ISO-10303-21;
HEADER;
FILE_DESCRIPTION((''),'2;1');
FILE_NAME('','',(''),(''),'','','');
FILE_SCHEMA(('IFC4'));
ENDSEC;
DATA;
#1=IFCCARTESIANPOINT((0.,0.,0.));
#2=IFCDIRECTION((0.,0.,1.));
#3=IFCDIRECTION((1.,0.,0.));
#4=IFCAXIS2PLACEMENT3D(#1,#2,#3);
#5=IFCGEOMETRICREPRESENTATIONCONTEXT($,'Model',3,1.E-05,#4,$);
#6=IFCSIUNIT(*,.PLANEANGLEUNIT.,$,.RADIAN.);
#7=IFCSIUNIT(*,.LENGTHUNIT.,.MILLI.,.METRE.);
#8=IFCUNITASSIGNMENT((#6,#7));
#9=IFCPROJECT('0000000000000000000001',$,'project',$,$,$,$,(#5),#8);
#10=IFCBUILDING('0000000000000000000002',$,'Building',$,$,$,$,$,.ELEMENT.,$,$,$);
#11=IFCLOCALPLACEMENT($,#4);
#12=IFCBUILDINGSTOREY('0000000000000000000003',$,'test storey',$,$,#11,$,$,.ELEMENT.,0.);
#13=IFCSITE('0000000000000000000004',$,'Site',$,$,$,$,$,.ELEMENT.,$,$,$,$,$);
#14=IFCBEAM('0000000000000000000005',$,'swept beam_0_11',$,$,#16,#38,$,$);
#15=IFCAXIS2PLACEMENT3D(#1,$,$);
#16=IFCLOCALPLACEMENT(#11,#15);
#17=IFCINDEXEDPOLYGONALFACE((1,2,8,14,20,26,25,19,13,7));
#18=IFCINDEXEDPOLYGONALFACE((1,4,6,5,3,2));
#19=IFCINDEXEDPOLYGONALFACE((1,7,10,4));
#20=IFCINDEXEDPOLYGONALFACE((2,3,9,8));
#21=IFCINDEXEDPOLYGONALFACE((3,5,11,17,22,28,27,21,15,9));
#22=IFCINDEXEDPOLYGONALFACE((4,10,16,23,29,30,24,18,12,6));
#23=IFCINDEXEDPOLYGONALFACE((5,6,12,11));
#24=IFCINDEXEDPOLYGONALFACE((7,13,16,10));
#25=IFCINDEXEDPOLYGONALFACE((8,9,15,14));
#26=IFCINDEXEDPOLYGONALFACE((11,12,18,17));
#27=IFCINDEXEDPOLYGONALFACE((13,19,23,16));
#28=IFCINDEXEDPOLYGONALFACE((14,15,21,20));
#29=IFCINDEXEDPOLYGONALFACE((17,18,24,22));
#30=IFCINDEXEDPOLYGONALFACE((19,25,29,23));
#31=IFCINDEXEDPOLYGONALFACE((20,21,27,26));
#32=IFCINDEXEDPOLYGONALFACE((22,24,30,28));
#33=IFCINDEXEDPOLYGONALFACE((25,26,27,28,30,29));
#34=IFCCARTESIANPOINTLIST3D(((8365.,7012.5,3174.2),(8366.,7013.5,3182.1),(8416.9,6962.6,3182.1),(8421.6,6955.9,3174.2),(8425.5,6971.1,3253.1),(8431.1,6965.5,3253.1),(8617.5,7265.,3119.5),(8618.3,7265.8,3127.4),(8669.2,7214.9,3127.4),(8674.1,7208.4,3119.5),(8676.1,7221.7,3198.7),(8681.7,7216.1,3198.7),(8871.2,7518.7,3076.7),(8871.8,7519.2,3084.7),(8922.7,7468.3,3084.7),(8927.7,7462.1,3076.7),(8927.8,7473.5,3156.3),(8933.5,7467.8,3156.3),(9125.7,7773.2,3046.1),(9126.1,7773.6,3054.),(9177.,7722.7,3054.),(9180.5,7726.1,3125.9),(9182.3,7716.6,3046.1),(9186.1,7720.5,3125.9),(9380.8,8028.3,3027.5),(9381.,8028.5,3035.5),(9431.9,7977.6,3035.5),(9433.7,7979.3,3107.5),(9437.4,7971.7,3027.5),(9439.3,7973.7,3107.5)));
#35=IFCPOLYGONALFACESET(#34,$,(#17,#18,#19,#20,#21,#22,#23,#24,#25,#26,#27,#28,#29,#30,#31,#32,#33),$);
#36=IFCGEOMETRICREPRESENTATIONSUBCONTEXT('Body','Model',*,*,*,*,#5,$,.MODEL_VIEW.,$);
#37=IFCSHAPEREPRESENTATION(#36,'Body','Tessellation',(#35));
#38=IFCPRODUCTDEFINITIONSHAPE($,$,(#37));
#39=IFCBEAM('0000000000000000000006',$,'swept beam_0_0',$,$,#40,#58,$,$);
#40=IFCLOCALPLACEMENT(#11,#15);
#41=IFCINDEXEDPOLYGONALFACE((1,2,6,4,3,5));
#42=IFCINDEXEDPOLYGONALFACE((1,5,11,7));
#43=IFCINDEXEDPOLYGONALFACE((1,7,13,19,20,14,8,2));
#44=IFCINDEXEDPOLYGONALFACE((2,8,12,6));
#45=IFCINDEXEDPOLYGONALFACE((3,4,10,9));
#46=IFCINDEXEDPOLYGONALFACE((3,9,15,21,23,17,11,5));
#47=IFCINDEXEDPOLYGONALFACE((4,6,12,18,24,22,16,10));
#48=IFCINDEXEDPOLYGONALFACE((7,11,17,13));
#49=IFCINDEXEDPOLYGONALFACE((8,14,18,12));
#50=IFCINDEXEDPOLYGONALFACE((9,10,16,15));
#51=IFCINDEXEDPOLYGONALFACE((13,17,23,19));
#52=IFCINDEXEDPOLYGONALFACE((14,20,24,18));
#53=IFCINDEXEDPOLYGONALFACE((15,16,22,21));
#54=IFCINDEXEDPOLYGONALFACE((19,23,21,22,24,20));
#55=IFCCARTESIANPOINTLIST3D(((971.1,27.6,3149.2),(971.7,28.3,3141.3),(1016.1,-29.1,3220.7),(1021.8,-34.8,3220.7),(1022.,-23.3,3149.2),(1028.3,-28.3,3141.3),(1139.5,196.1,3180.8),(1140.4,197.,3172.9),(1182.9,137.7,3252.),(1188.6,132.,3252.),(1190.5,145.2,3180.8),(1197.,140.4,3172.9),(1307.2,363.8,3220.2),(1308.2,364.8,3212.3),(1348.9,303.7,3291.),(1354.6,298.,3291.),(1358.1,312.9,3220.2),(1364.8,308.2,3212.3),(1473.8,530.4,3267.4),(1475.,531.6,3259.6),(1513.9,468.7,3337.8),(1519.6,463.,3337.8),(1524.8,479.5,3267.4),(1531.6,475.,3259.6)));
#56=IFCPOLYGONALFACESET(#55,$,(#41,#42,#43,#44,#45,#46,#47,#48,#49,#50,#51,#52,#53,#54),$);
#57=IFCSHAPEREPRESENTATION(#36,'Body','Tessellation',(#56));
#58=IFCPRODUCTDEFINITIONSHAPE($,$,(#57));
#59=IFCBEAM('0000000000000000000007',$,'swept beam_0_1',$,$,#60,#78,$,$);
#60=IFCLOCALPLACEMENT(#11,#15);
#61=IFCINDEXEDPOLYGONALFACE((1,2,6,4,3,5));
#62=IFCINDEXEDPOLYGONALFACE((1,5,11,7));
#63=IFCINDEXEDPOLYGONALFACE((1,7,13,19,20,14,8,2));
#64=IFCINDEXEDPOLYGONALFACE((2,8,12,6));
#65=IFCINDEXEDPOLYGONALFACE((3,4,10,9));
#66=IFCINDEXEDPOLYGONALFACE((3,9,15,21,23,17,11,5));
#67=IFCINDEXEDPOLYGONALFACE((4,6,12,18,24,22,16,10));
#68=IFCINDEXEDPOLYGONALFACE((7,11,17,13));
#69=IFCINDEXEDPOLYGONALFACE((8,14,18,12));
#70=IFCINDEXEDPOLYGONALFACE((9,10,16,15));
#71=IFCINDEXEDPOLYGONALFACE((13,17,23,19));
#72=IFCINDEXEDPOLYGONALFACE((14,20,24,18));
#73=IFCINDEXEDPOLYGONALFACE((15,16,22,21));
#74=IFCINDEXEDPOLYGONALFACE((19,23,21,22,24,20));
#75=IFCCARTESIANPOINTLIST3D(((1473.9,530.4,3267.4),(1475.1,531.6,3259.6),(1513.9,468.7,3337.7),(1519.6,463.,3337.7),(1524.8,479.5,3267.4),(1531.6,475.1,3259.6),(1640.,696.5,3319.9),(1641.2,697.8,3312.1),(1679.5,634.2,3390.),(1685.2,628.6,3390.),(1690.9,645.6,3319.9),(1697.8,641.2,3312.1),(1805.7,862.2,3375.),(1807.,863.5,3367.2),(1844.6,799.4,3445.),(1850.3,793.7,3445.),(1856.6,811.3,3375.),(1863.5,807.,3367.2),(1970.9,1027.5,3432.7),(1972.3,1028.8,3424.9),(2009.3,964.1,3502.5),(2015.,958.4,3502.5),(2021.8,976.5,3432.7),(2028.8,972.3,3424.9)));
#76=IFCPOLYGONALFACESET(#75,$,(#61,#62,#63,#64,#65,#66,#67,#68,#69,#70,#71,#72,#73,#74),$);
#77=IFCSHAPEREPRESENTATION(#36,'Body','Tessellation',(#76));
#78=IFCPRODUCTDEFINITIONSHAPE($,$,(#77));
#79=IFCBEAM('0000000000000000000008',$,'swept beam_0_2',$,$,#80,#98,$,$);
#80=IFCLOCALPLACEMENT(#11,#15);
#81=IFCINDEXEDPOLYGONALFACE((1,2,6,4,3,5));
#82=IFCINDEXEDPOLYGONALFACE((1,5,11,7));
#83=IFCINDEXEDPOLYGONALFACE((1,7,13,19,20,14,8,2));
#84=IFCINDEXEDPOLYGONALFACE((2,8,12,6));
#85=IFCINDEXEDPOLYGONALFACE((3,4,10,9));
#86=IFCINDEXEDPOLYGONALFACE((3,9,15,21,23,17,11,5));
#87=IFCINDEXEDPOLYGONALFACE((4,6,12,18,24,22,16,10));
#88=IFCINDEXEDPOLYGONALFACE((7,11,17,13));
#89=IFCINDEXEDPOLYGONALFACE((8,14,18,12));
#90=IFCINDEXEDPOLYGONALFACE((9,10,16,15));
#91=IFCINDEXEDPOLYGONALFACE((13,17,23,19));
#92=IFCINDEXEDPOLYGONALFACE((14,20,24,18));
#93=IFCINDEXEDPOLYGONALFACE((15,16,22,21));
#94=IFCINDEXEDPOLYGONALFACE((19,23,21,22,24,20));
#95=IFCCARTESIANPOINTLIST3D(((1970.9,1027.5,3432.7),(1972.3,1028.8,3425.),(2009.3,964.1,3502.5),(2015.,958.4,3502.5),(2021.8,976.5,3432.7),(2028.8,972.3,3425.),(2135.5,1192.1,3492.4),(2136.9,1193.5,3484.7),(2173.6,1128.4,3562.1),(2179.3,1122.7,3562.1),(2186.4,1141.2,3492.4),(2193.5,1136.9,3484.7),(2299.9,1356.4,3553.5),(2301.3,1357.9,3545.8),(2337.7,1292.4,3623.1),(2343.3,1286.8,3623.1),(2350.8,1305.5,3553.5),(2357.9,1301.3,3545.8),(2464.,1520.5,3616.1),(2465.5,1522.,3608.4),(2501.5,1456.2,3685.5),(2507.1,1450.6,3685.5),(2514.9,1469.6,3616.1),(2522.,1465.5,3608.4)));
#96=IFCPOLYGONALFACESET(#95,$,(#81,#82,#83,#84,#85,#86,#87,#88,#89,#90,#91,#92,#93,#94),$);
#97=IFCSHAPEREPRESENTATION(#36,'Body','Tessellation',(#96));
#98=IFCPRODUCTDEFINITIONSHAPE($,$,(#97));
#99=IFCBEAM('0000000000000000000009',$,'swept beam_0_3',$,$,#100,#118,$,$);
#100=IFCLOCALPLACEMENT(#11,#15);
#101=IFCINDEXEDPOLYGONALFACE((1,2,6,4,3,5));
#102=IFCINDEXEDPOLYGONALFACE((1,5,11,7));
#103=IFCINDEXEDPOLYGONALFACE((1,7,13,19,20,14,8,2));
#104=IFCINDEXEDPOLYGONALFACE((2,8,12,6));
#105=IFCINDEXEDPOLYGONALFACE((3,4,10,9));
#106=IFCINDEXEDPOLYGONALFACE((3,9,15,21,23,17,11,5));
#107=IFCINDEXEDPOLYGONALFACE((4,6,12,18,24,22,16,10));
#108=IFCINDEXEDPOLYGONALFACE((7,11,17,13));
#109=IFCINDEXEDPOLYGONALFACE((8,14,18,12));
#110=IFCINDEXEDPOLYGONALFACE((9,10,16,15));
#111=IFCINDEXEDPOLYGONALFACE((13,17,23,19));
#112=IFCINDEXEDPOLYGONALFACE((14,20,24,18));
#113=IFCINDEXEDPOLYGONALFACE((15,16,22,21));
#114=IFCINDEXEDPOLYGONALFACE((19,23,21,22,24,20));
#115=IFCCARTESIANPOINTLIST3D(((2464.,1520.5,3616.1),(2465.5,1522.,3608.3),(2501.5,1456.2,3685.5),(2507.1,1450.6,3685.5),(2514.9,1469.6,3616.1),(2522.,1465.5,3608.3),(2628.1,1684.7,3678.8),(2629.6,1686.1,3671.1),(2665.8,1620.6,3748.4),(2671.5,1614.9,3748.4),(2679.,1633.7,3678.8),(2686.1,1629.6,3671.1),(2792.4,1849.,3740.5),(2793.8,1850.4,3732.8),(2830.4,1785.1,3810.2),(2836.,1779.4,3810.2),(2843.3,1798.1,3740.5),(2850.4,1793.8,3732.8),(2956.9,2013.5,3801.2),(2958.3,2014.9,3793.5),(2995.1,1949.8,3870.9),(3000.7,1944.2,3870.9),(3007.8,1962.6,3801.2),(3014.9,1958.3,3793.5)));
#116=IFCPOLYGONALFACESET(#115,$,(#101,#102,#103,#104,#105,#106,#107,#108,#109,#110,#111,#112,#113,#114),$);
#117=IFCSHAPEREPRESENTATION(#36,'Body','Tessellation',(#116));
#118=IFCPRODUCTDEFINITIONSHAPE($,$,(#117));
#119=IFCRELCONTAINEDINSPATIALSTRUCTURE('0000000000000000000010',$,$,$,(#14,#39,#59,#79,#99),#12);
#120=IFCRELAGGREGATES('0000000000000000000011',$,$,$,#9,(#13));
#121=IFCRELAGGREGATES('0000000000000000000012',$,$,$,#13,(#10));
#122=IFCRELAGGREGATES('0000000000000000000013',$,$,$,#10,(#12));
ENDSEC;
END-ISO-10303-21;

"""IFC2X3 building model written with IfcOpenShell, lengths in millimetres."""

from ifc_helpers import new_model, entity, si_unit, origin_with_axes, place, context, subcontext, project, spatial, element, save


model = new_model("IFC2X3")

# Units and contexts
model_context = context("Model", 3, precision=1e-05, world=origin_with_axes())
body_context = subcontext(model_context, "Body", "Model", "MODEL_VIEW")
ifc_project = project(units=[si_unit("PLANEANGLEUNIT", "RADIAN"), si_unit("LENGTHUNIT", "METRE", prefix="MILLI")], contexts=[model_context])

# Site, building, storey
site = spatial("IfcSite", under=ifc_project, Name="Site", CompositionType="ELEMENT")
building = spatial("IfcBuilding", under=site, Name="Building", CompositionType="ELEMENT")
storey_placement = place(None, origin_with_axes())
storey = spatial("IfcBuildingStorey", under=building, at=storey_placement, Name="test storey", CompositionType="ELEMENT", Elevation=0.0)

# Beams
beam_1_placement = place(storey_placement, origin_with_axes())
element("IfcBeam", 1, at=beam_1_placement, inside=storey, Name="swept beam_0_11", context=body_context, shape_type="SweptSolid", body=[
    entity("IfcRevolvedAreaSolid", entity("IfcArbitraryClosedProfileDef", "AREA", None, entity("IfcPolyline", [entity("IfcCartesianPoint", [-80.0, 40.0]), entity("IfcCartesianPoint", [-80.0, 32.0]), entity("IfcCartesianPoint", [-8.0, 32.0]), entity("IfcCartesianPoint", [-8.0, -40.0]), entity("IfcCartesianPoint", [0.0, -40.0]), entity("IfcCartesianPoint", [0.0, 40.0]), entity("IfcCartesianPoint", [-80.0, 40.0])])), entity("IfcAxis2Placement3D", entity("IfcCartesianPoint", [8393.3, 6984.2, 3174.2]), entity("IfcDirection", [-0.697, -0.697, 0.1682]), entity("IfcDirection", [-0.119, -0.119, -0.9857])), entity("IfcAxis1Placement", entity("IfcCartesianPoint", [-10749.5, 0.0, 0.0]), entity("IfcDirection", [0.0, 1.0, 0.0])), 0.134433),
])
beam_2_placement = place(storey_placement, origin_with_axes())
element("IfcBeam", 2, at=beam_2_placement, inside=storey, Name="swept beam_0_0", context=body_context, shape_type="SweptSolid", body=[
    entity("IfcRevolvedAreaSolid", entity("IfcArbitraryClosedProfileDef", "AREA", None, entity("IfcPolyline", [entity("IfcCartesianPoint", [-80.0, 40.0]), entity("IfcCartesianPoint", [-80.0, 32.0]), entity("IfcCartesianPoint", [-8.0, 32.0]), entity("IfcCartesianPoint", [-8.0, -40.0]), entity("IfcCartesianPoint", [0.0, -40.0]), entity("IfcCartesianPoint", [0.0, 40.0]), entity("IfcCartesianPoint", [-80.0, 40.0])])), entity("IfcAxis2Placement3D", entity("IfcCartesianPoint", [1000.0, 0.0, 3141.3]), entity("IfcDirection", [-0.7024, -0.7024, -0.115]), entity("IfcDirection", [0.0813, 0.0813, -0.9934])), entity("IfcAxis1Placement", entity("IfcCartesianPoint", [-7295.8, 0.0, 0.0]), entity("IfcDirection", [0.0, 1.0, 0.0])), 0.098945),
])
beam_3_placement = place(storey_placement, origin_with_axes())
element("IfcBeam", 3, at=beam_3_placement, inside=storey, Name="swept beam_0_1", context=body_context, shape_type="SweptSolid", body=[
    entity("IfcRevolvedAreaSolid", entity("IfcArbitraryClosedProfileDef", "AREA", None, entity("IfcPolyline", [entity("IfcCartesianPoint", [-80.0, 40.0]), entity("IfcCartesianPoint", [-80.0, 32.0]), entity("IfcCartesianPoint", [-8.0, 32.0]), entity("IfcCartesianPoint", [-8.0, -40.0]), entity("IfcCartesianPoint", [0.0, -40.0]), entity("IfcCartesianPoint", [0.0, 40.0]), entity("IfcCartesianPoint", [-80.0, 40.0])])), entity("IfcAxis2Placement3D", entity("IfcCartesianPoint", [1503.3, 503.3, 3259.6]), entity("IfcDirection", [-0.691, -0.691, -0.2125]), entity("IfcDirection", [0.1503, 0.1503, -0.9772])), entity("IfcAxis1Placement", entity("IfcCartesianPoint", [-21405.3, 0.0, 0.0]), entity("IfcDirection", [0.0, 1.0, 0.0])), 0.033749),
])
beam_4_placement = place(storey_placement, origin_with_axes())
element("IfcBeam", 4, at=beam_4_placement, inside=storey, Name="swept beam_0_2", context=body_context, shape_type="SweptSolid", body=[
    entity("IfcRevolvedAreaSolid", entity("IfcArbitraryClosedProfileDef", "AREA", None, entity("IfcPolyline", [entity("IfcCartesianPoint", [-80.0, 40.0]), entity("IfcCartesianPoint", [-80.0, 32.0]), entity("IfcCartesianPoint", [-8.0, 32.0]), entity("IfcCartesianPoint", [-8.0, -40.0]), entity("IfcCartesianPoint", [0.0, -40.0]), entity("IfcCartesianPoint", [0.0, 40.0]), entity("IfcCartesianPoint", [-80.0, 40.0])])), entity("IfcAxis2Placement3D", entity("IfcCartesianPoint", [2000.6, 1000.6, 3425.0]), entity("IfcDirection", [-0.6855, -0.6855, -0.2454]), entity("IfcDirection", [0.1735, 0.1735, -0.9694])), entity("IfcAxis1Placement", entity("IfcCartesianPoint", [-39230.2, 0.0, 0.0]), entity("IfcDirection", [0.0, 1.0, 0.0])), 0.018383),
])
beam_5_placement = place(storey_placement, origin_with_axes())
element("IfcBeam", 5, at=beam_5_placement, inside=storey, Name="swept beam_0_3", context=body_context, shape_type="SweptSolid", body=[
    entity("IfcRevolvedAreaSolid", entity("IfcArbitraryClosedProfileDef", "AREA", None, entity("IfcPolyline", [entity("IfcCartesianPoint", [80.0, -40.0]), entity("IfcCartesianPoint", [80.0, -32.0]), entity("IfcCartesianPoint", [8.0, -32.0]), entity("IfcCartesianPoint", [8.0, 40.0]), entity("IfcCartesianPoint", [0.0, 40.0]), entity("IfcCartesianPoint", [0.0, -40.0]), entity("IfcCartesianPoint", [80.0, -40.0])])), entity("IfcAxis2Placement3D", entity("IfcCartesianPoint", [2493.7, 1493.7, 3608.3]), entity("IfcDirection", [-0.6822, -0.6822, -0.2632]), entity("IfcDirection", [-0.1861, -0.1861, 0.9648])), entity("IfcAxis1Placement", entity("IfcCartesianPoint", [-53793.7, 0.0, 0.0]), entity("IfcDirection", [0.0, 1.0, 0.0])), 0.013407),
])

save(model, "model.ifc")
